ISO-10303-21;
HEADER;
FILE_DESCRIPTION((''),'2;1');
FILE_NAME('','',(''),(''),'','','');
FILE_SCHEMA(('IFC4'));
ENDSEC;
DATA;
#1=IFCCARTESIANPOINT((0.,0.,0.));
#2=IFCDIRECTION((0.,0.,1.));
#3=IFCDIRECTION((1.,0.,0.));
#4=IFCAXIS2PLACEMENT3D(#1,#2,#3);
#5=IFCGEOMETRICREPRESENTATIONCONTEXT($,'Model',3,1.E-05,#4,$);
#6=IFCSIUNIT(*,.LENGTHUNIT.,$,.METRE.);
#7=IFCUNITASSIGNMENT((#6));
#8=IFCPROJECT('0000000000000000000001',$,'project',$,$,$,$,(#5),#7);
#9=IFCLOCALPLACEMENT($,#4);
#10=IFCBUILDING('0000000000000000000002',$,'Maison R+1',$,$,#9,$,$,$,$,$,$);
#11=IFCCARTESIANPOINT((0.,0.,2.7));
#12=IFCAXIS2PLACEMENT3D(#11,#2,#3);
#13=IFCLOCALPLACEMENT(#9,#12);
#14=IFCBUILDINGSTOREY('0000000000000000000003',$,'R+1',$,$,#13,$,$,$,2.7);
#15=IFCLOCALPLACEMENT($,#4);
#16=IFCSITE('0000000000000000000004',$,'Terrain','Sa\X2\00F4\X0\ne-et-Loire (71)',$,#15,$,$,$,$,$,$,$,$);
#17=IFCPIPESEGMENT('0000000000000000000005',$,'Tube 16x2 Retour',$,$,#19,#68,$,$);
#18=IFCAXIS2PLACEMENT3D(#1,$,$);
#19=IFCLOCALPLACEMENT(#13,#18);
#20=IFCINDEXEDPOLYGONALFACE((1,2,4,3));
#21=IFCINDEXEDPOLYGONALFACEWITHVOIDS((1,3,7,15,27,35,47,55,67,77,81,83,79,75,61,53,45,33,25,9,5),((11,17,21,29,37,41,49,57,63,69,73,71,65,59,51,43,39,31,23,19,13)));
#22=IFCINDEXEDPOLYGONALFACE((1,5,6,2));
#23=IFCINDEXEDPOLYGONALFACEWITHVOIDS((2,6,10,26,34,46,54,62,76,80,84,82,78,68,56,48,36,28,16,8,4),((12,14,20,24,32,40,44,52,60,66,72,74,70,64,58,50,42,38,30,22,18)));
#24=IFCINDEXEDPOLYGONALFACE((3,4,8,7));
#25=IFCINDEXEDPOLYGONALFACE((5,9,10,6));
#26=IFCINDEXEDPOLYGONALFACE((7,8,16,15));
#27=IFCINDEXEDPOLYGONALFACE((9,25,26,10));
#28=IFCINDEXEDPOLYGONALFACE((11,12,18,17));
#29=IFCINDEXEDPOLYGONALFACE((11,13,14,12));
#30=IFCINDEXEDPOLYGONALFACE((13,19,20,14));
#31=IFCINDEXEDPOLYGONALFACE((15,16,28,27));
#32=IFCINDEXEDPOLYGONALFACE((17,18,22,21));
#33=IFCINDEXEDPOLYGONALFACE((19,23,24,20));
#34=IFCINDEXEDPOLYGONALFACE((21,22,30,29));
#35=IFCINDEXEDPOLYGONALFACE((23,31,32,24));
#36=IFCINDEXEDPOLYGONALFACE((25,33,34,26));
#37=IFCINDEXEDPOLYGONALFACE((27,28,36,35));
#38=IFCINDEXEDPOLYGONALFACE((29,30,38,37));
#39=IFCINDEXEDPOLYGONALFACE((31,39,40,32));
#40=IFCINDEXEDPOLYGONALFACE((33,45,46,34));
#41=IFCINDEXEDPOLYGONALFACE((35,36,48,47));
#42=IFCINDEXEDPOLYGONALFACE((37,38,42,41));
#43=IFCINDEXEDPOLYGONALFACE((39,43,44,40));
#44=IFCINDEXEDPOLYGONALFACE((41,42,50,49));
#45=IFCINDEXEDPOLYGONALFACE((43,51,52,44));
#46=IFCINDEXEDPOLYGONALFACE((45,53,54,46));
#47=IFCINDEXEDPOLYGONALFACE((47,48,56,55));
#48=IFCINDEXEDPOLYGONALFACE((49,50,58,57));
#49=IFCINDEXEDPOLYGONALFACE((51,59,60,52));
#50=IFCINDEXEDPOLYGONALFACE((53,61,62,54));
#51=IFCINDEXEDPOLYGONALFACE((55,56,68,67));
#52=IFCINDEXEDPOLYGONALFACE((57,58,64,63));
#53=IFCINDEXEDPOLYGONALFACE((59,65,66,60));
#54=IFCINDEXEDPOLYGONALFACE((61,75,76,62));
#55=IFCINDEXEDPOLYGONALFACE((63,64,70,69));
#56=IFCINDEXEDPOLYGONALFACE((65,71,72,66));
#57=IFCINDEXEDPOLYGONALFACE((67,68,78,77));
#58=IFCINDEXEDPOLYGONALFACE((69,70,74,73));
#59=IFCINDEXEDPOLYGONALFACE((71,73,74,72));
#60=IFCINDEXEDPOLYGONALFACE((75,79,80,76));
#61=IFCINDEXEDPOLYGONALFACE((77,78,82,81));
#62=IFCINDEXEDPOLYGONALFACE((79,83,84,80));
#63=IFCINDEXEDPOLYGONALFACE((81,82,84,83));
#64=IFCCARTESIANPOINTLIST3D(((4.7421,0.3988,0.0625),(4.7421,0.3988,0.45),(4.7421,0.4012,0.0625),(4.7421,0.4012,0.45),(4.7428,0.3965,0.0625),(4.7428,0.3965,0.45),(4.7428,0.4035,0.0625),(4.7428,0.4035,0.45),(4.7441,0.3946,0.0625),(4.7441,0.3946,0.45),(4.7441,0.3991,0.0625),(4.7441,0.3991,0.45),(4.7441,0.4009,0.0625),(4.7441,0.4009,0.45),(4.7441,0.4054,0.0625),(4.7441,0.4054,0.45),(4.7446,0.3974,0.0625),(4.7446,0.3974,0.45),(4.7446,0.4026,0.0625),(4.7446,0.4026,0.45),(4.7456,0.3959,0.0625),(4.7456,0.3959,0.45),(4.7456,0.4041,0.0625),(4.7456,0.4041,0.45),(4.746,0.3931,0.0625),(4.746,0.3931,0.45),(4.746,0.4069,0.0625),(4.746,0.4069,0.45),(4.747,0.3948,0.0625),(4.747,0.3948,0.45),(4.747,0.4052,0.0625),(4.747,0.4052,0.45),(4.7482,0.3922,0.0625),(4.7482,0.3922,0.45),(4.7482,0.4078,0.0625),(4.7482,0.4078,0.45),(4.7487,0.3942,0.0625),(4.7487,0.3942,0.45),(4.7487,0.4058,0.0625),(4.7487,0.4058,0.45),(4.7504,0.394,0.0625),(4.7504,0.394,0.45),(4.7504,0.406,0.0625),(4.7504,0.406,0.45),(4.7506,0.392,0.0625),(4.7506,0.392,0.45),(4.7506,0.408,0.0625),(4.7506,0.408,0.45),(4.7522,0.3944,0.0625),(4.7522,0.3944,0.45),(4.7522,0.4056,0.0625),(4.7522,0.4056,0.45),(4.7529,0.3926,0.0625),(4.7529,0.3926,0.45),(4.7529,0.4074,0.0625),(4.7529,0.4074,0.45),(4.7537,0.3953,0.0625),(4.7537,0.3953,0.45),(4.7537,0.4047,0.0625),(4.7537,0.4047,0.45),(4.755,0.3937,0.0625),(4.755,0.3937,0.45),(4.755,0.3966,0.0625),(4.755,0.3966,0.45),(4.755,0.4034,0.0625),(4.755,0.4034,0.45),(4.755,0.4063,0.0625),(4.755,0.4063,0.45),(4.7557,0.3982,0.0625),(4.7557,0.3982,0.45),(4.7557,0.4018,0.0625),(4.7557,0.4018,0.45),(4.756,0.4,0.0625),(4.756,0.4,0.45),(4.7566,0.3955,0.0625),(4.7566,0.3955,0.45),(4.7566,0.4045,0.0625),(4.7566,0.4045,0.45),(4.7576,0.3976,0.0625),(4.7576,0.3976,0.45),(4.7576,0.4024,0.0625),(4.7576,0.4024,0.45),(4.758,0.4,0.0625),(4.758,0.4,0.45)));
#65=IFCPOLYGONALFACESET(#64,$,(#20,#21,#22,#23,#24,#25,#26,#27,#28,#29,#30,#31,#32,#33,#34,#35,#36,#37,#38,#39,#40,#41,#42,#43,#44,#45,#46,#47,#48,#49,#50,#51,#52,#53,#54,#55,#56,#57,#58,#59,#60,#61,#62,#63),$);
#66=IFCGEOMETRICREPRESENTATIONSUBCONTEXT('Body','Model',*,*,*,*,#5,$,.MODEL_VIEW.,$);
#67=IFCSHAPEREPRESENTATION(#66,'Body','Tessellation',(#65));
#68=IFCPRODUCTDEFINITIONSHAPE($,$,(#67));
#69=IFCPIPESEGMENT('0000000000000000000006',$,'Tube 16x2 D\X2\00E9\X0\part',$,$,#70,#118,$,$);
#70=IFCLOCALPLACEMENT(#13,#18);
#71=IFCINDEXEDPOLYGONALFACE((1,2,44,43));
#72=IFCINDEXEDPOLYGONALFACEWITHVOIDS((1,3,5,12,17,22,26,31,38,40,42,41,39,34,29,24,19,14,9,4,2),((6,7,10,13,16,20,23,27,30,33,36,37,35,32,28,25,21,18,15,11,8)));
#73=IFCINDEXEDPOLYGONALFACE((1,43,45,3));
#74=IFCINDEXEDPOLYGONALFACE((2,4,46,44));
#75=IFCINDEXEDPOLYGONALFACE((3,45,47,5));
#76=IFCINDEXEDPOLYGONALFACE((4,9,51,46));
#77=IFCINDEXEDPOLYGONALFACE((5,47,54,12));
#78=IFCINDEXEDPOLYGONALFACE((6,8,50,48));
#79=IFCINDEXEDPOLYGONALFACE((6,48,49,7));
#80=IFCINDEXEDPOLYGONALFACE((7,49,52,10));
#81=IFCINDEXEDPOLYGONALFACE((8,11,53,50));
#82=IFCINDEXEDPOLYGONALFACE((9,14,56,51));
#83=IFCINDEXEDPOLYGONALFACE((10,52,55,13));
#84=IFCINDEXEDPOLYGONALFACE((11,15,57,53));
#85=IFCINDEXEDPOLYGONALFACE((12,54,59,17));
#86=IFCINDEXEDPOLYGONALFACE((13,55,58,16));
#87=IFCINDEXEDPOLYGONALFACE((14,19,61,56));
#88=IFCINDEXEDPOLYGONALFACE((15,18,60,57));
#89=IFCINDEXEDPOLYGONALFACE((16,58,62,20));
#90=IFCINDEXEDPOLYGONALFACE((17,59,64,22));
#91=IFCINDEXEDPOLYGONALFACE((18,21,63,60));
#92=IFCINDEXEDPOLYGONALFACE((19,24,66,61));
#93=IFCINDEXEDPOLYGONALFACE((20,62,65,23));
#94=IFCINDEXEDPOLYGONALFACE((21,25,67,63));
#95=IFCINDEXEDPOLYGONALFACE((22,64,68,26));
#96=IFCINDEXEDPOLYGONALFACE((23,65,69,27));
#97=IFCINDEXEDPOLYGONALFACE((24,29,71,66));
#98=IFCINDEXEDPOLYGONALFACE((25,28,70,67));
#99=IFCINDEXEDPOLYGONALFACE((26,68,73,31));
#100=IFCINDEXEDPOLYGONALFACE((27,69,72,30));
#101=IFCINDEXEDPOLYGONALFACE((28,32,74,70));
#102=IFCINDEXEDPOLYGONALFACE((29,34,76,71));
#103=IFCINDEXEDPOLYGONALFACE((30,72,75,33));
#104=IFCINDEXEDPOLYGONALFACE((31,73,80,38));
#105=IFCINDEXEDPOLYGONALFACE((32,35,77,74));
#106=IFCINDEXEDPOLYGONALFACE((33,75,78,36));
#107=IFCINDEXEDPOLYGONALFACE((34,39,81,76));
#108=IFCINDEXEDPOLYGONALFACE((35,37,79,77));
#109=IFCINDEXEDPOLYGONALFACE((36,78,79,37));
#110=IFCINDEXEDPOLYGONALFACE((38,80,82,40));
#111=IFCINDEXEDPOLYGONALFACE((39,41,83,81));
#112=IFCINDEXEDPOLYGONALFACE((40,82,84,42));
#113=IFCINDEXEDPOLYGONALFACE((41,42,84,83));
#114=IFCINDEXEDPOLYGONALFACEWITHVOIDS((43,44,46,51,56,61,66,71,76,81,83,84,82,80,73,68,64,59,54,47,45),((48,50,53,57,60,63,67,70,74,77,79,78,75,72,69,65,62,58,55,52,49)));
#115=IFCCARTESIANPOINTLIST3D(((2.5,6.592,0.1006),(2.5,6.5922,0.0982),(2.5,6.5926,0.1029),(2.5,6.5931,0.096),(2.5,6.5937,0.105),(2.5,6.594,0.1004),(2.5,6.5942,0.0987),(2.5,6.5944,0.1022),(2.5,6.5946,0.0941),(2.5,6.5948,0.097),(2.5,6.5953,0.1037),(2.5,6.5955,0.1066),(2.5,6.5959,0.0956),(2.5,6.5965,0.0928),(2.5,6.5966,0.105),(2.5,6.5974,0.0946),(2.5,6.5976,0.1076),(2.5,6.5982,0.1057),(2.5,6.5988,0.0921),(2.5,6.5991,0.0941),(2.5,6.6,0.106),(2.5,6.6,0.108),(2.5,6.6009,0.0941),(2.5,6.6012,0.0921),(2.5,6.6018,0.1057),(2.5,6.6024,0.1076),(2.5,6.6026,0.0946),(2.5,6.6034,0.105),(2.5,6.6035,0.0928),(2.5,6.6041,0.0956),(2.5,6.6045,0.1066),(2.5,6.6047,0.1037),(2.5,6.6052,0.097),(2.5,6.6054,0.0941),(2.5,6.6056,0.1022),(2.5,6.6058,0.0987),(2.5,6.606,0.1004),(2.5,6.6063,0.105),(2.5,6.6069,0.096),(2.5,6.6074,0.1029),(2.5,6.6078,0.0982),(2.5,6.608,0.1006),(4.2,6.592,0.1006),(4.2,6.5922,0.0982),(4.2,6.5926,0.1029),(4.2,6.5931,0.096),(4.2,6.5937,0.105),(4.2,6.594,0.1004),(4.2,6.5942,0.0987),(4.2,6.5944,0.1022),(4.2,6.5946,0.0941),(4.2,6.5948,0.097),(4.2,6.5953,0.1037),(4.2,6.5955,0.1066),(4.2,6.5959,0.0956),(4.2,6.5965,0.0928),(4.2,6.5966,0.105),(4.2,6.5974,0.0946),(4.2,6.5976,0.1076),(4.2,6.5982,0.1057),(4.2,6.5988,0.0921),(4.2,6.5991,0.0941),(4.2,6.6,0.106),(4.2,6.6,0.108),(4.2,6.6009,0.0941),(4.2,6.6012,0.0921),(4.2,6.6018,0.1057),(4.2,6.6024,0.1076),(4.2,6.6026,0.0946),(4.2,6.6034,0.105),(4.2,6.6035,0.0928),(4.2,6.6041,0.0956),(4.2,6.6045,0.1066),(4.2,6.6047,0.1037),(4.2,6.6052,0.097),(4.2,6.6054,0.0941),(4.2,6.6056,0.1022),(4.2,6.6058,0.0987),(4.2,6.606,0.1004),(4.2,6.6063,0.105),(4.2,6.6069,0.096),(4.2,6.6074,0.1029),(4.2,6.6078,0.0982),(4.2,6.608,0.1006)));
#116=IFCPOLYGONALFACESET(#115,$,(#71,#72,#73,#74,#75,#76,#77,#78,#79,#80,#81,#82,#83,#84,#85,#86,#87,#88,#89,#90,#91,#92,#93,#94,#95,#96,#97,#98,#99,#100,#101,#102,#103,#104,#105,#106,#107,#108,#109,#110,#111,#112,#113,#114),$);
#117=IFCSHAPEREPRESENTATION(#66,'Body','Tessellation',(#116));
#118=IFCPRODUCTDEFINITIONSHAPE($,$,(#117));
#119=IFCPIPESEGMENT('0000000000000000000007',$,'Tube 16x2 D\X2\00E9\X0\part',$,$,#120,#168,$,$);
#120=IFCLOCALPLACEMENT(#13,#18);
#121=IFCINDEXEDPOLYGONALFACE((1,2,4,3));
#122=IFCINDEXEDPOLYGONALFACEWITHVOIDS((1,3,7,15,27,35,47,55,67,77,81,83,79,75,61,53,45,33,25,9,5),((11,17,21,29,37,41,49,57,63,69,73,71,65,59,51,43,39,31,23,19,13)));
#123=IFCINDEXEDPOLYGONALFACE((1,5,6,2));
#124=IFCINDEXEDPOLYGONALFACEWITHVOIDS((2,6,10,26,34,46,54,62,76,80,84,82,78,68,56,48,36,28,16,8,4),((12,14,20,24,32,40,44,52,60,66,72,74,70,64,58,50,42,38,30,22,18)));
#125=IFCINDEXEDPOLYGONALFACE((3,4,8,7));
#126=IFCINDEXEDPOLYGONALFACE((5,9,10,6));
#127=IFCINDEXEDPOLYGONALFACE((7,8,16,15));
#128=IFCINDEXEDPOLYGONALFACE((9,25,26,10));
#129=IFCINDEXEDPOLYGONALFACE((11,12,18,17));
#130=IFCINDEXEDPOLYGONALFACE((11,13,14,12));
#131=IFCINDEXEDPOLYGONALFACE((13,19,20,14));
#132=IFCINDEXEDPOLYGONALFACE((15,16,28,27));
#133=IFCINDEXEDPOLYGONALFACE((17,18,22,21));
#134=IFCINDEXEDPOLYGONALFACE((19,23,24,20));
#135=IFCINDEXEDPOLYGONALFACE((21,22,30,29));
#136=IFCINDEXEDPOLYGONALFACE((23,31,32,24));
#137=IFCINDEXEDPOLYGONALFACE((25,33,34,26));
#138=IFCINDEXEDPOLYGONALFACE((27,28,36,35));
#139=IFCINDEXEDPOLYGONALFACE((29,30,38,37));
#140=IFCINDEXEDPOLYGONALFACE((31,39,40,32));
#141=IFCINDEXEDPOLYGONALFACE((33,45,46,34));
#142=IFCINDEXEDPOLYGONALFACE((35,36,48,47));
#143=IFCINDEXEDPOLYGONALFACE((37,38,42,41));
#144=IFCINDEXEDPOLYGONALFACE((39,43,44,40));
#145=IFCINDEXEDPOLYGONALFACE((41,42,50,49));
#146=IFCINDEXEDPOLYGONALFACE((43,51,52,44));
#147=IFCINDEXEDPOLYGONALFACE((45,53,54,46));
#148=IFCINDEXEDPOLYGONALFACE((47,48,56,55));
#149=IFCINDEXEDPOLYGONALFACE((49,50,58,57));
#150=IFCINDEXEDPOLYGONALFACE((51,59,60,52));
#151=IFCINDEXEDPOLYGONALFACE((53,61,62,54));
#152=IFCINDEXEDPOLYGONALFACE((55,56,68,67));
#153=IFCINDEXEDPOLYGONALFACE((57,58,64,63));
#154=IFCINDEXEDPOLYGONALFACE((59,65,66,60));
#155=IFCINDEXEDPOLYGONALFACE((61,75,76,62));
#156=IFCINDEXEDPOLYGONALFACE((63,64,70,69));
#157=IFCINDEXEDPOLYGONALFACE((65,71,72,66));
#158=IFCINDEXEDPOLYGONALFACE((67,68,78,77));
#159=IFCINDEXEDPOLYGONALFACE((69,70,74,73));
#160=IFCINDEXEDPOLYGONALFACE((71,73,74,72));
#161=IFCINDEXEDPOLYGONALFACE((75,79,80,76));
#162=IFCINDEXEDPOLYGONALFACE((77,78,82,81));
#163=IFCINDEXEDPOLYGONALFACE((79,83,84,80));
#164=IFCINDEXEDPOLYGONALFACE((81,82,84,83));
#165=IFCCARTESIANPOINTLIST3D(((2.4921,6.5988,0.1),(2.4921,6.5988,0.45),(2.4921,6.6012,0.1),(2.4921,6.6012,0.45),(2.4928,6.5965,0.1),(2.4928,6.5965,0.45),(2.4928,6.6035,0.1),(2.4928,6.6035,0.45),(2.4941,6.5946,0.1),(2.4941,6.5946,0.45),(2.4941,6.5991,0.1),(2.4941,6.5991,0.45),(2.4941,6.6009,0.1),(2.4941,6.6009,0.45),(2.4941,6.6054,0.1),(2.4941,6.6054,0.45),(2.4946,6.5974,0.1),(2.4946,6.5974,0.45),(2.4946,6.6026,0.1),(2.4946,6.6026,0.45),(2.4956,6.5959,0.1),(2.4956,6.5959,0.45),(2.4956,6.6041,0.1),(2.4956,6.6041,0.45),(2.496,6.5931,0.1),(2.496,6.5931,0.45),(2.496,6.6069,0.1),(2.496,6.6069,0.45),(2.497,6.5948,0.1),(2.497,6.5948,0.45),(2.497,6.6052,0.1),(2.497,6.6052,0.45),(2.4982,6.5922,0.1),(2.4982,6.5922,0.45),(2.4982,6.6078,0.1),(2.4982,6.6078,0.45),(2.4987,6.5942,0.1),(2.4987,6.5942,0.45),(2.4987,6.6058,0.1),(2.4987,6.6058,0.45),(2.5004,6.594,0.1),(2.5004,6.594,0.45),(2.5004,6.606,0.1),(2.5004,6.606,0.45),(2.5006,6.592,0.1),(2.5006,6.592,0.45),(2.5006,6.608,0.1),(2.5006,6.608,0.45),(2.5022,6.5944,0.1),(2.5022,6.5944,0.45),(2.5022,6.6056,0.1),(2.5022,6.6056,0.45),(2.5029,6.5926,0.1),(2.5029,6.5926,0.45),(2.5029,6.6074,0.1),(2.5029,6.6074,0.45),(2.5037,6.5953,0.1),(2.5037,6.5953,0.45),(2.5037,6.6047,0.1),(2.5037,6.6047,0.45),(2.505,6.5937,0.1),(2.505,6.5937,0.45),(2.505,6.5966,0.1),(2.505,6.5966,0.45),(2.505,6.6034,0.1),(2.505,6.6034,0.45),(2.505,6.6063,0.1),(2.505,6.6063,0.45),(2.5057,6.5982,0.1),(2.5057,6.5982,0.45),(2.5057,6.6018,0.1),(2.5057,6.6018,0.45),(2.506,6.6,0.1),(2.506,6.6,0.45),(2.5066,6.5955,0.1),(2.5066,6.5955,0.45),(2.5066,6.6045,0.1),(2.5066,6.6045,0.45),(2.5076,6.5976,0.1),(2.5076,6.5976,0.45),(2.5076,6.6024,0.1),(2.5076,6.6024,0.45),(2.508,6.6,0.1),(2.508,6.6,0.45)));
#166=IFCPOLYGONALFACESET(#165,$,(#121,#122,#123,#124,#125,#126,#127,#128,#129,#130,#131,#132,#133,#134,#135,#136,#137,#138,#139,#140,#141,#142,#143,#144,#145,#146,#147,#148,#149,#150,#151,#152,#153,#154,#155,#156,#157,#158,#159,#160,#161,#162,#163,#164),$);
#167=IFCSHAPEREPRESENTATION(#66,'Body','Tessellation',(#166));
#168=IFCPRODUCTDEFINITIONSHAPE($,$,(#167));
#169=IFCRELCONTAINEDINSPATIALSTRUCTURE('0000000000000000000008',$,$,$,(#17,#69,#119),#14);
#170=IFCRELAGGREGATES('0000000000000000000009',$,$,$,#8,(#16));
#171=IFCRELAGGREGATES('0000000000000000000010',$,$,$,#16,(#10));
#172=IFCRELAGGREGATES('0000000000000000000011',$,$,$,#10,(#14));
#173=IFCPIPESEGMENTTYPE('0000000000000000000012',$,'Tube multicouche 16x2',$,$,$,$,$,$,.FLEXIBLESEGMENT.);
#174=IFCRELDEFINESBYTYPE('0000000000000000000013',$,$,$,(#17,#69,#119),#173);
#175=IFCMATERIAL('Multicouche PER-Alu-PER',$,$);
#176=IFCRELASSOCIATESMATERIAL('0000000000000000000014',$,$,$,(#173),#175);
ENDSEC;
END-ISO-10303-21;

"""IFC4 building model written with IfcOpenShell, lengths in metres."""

from ifc_helpers import new_model, si_unit, frame, origin_with_axes, place, context, subcontext, project, spatial, hollow_circle, extrude, material, type_object, element, save


model = new_model("IFC4")

# Units and contexts
model_context = context("Model", 3, precision=1e-05, world=origin_with_axes())
body_context = subcontext(model_context, "Body", "Model", "MODEL_VIEW")
ifc_project = project(units=[si_unit("LENGTHUNIT", "METRE")], contexts=[model_context])

# Site, building, storey
site_placement = place(None, origin_with_axes())
site = spatial("IfcSite", under=ifc_project, at=site_placement, Name="Terrain", Description="Saône-et-Loire (71)")
building_placement = place(None, origin_with_axes())
building = spatial("IfcBuilding", under=site, at=building_placement, Name="Maison R+1")
storey_placement = place(building_placement, frame((0.0, 0.0, 2.7), z_axis=(0.0, 0.0, 1.0), x_axis=(1.0, 0.0, 0.0)))
storey = spatial("IfcBuildingStorey", under=building, at=storey_placement, Name="R+1", Elevation=2.7)

# Pipe segments
ifc_material_1 = material(Name="Multicouche PER-Alu-PER")
pipe_segment_type = type_object("IfcPipeSegmentType", Name="Tube multicouche 16x2", PredefinedType="FLEXIBLESEGMENT", material=ifc_material_1)
pipe_segment_1_placement = place(storey_placement, frame((4.75, 0.4, 0.0625), z_axis=(0.0, 0.0, 1.0), x_axis=(1.0, 0.0, 0.0)))
element("IfcPipeSegment", 1, at=pipe_segment_1_placement, inside=storey, type_object=pipe_segment_type, Name="Tube 16x2 Retour", context=body_context, shape_type="SweptSolid", body=[
    extrude(hollow_circle(Radius=0.008, WallThickness=0.002), origin_with_axes(), (0.0, 0.0, 1.0), 0.3875),
])
pipe_segment_2_placement = place(storey_placement, frame((4.2, 6.6, 0.1), z_axis=(-1.0, 0.0, 0.0), x_axis=(0.0, 0.0, 1.0)))
element("IfcPipeSegment", 2, at=pipe_segment_2_placement, inside=storey, type_object=pipe_segment_type, Name="Tube 16x2 Départ", context=body_context, shape_type="SweptSolid", body=[
    extrude(hollow_circle(Radius=0.008, WallThickness=0.002), origin_with_axes(), (0.0, 0.0, 1.0), 1.7),
])
pipe_segment_3_placement = place(storey_placement, frame((2.5, 6.6, 0.1), z_axis=(0.0, 0.0, 1.0), x_axis=(1.0, 0.0, 0.0)))
element("IfcPipeSegment", 3, at=pipe_segment_3_placement, inside=storey, type_object=pipe_segment_type, Name="Tube 16x2 Départ", context=body_context, shape_type="SweptSolid", body=[
    extrude(hollow_circle(Radius=0.008, WallThickness=0.002), origin_with_axes(), (0.0, 0.0, 1.0), 0.35),
])

save(model, "model.ifc")
